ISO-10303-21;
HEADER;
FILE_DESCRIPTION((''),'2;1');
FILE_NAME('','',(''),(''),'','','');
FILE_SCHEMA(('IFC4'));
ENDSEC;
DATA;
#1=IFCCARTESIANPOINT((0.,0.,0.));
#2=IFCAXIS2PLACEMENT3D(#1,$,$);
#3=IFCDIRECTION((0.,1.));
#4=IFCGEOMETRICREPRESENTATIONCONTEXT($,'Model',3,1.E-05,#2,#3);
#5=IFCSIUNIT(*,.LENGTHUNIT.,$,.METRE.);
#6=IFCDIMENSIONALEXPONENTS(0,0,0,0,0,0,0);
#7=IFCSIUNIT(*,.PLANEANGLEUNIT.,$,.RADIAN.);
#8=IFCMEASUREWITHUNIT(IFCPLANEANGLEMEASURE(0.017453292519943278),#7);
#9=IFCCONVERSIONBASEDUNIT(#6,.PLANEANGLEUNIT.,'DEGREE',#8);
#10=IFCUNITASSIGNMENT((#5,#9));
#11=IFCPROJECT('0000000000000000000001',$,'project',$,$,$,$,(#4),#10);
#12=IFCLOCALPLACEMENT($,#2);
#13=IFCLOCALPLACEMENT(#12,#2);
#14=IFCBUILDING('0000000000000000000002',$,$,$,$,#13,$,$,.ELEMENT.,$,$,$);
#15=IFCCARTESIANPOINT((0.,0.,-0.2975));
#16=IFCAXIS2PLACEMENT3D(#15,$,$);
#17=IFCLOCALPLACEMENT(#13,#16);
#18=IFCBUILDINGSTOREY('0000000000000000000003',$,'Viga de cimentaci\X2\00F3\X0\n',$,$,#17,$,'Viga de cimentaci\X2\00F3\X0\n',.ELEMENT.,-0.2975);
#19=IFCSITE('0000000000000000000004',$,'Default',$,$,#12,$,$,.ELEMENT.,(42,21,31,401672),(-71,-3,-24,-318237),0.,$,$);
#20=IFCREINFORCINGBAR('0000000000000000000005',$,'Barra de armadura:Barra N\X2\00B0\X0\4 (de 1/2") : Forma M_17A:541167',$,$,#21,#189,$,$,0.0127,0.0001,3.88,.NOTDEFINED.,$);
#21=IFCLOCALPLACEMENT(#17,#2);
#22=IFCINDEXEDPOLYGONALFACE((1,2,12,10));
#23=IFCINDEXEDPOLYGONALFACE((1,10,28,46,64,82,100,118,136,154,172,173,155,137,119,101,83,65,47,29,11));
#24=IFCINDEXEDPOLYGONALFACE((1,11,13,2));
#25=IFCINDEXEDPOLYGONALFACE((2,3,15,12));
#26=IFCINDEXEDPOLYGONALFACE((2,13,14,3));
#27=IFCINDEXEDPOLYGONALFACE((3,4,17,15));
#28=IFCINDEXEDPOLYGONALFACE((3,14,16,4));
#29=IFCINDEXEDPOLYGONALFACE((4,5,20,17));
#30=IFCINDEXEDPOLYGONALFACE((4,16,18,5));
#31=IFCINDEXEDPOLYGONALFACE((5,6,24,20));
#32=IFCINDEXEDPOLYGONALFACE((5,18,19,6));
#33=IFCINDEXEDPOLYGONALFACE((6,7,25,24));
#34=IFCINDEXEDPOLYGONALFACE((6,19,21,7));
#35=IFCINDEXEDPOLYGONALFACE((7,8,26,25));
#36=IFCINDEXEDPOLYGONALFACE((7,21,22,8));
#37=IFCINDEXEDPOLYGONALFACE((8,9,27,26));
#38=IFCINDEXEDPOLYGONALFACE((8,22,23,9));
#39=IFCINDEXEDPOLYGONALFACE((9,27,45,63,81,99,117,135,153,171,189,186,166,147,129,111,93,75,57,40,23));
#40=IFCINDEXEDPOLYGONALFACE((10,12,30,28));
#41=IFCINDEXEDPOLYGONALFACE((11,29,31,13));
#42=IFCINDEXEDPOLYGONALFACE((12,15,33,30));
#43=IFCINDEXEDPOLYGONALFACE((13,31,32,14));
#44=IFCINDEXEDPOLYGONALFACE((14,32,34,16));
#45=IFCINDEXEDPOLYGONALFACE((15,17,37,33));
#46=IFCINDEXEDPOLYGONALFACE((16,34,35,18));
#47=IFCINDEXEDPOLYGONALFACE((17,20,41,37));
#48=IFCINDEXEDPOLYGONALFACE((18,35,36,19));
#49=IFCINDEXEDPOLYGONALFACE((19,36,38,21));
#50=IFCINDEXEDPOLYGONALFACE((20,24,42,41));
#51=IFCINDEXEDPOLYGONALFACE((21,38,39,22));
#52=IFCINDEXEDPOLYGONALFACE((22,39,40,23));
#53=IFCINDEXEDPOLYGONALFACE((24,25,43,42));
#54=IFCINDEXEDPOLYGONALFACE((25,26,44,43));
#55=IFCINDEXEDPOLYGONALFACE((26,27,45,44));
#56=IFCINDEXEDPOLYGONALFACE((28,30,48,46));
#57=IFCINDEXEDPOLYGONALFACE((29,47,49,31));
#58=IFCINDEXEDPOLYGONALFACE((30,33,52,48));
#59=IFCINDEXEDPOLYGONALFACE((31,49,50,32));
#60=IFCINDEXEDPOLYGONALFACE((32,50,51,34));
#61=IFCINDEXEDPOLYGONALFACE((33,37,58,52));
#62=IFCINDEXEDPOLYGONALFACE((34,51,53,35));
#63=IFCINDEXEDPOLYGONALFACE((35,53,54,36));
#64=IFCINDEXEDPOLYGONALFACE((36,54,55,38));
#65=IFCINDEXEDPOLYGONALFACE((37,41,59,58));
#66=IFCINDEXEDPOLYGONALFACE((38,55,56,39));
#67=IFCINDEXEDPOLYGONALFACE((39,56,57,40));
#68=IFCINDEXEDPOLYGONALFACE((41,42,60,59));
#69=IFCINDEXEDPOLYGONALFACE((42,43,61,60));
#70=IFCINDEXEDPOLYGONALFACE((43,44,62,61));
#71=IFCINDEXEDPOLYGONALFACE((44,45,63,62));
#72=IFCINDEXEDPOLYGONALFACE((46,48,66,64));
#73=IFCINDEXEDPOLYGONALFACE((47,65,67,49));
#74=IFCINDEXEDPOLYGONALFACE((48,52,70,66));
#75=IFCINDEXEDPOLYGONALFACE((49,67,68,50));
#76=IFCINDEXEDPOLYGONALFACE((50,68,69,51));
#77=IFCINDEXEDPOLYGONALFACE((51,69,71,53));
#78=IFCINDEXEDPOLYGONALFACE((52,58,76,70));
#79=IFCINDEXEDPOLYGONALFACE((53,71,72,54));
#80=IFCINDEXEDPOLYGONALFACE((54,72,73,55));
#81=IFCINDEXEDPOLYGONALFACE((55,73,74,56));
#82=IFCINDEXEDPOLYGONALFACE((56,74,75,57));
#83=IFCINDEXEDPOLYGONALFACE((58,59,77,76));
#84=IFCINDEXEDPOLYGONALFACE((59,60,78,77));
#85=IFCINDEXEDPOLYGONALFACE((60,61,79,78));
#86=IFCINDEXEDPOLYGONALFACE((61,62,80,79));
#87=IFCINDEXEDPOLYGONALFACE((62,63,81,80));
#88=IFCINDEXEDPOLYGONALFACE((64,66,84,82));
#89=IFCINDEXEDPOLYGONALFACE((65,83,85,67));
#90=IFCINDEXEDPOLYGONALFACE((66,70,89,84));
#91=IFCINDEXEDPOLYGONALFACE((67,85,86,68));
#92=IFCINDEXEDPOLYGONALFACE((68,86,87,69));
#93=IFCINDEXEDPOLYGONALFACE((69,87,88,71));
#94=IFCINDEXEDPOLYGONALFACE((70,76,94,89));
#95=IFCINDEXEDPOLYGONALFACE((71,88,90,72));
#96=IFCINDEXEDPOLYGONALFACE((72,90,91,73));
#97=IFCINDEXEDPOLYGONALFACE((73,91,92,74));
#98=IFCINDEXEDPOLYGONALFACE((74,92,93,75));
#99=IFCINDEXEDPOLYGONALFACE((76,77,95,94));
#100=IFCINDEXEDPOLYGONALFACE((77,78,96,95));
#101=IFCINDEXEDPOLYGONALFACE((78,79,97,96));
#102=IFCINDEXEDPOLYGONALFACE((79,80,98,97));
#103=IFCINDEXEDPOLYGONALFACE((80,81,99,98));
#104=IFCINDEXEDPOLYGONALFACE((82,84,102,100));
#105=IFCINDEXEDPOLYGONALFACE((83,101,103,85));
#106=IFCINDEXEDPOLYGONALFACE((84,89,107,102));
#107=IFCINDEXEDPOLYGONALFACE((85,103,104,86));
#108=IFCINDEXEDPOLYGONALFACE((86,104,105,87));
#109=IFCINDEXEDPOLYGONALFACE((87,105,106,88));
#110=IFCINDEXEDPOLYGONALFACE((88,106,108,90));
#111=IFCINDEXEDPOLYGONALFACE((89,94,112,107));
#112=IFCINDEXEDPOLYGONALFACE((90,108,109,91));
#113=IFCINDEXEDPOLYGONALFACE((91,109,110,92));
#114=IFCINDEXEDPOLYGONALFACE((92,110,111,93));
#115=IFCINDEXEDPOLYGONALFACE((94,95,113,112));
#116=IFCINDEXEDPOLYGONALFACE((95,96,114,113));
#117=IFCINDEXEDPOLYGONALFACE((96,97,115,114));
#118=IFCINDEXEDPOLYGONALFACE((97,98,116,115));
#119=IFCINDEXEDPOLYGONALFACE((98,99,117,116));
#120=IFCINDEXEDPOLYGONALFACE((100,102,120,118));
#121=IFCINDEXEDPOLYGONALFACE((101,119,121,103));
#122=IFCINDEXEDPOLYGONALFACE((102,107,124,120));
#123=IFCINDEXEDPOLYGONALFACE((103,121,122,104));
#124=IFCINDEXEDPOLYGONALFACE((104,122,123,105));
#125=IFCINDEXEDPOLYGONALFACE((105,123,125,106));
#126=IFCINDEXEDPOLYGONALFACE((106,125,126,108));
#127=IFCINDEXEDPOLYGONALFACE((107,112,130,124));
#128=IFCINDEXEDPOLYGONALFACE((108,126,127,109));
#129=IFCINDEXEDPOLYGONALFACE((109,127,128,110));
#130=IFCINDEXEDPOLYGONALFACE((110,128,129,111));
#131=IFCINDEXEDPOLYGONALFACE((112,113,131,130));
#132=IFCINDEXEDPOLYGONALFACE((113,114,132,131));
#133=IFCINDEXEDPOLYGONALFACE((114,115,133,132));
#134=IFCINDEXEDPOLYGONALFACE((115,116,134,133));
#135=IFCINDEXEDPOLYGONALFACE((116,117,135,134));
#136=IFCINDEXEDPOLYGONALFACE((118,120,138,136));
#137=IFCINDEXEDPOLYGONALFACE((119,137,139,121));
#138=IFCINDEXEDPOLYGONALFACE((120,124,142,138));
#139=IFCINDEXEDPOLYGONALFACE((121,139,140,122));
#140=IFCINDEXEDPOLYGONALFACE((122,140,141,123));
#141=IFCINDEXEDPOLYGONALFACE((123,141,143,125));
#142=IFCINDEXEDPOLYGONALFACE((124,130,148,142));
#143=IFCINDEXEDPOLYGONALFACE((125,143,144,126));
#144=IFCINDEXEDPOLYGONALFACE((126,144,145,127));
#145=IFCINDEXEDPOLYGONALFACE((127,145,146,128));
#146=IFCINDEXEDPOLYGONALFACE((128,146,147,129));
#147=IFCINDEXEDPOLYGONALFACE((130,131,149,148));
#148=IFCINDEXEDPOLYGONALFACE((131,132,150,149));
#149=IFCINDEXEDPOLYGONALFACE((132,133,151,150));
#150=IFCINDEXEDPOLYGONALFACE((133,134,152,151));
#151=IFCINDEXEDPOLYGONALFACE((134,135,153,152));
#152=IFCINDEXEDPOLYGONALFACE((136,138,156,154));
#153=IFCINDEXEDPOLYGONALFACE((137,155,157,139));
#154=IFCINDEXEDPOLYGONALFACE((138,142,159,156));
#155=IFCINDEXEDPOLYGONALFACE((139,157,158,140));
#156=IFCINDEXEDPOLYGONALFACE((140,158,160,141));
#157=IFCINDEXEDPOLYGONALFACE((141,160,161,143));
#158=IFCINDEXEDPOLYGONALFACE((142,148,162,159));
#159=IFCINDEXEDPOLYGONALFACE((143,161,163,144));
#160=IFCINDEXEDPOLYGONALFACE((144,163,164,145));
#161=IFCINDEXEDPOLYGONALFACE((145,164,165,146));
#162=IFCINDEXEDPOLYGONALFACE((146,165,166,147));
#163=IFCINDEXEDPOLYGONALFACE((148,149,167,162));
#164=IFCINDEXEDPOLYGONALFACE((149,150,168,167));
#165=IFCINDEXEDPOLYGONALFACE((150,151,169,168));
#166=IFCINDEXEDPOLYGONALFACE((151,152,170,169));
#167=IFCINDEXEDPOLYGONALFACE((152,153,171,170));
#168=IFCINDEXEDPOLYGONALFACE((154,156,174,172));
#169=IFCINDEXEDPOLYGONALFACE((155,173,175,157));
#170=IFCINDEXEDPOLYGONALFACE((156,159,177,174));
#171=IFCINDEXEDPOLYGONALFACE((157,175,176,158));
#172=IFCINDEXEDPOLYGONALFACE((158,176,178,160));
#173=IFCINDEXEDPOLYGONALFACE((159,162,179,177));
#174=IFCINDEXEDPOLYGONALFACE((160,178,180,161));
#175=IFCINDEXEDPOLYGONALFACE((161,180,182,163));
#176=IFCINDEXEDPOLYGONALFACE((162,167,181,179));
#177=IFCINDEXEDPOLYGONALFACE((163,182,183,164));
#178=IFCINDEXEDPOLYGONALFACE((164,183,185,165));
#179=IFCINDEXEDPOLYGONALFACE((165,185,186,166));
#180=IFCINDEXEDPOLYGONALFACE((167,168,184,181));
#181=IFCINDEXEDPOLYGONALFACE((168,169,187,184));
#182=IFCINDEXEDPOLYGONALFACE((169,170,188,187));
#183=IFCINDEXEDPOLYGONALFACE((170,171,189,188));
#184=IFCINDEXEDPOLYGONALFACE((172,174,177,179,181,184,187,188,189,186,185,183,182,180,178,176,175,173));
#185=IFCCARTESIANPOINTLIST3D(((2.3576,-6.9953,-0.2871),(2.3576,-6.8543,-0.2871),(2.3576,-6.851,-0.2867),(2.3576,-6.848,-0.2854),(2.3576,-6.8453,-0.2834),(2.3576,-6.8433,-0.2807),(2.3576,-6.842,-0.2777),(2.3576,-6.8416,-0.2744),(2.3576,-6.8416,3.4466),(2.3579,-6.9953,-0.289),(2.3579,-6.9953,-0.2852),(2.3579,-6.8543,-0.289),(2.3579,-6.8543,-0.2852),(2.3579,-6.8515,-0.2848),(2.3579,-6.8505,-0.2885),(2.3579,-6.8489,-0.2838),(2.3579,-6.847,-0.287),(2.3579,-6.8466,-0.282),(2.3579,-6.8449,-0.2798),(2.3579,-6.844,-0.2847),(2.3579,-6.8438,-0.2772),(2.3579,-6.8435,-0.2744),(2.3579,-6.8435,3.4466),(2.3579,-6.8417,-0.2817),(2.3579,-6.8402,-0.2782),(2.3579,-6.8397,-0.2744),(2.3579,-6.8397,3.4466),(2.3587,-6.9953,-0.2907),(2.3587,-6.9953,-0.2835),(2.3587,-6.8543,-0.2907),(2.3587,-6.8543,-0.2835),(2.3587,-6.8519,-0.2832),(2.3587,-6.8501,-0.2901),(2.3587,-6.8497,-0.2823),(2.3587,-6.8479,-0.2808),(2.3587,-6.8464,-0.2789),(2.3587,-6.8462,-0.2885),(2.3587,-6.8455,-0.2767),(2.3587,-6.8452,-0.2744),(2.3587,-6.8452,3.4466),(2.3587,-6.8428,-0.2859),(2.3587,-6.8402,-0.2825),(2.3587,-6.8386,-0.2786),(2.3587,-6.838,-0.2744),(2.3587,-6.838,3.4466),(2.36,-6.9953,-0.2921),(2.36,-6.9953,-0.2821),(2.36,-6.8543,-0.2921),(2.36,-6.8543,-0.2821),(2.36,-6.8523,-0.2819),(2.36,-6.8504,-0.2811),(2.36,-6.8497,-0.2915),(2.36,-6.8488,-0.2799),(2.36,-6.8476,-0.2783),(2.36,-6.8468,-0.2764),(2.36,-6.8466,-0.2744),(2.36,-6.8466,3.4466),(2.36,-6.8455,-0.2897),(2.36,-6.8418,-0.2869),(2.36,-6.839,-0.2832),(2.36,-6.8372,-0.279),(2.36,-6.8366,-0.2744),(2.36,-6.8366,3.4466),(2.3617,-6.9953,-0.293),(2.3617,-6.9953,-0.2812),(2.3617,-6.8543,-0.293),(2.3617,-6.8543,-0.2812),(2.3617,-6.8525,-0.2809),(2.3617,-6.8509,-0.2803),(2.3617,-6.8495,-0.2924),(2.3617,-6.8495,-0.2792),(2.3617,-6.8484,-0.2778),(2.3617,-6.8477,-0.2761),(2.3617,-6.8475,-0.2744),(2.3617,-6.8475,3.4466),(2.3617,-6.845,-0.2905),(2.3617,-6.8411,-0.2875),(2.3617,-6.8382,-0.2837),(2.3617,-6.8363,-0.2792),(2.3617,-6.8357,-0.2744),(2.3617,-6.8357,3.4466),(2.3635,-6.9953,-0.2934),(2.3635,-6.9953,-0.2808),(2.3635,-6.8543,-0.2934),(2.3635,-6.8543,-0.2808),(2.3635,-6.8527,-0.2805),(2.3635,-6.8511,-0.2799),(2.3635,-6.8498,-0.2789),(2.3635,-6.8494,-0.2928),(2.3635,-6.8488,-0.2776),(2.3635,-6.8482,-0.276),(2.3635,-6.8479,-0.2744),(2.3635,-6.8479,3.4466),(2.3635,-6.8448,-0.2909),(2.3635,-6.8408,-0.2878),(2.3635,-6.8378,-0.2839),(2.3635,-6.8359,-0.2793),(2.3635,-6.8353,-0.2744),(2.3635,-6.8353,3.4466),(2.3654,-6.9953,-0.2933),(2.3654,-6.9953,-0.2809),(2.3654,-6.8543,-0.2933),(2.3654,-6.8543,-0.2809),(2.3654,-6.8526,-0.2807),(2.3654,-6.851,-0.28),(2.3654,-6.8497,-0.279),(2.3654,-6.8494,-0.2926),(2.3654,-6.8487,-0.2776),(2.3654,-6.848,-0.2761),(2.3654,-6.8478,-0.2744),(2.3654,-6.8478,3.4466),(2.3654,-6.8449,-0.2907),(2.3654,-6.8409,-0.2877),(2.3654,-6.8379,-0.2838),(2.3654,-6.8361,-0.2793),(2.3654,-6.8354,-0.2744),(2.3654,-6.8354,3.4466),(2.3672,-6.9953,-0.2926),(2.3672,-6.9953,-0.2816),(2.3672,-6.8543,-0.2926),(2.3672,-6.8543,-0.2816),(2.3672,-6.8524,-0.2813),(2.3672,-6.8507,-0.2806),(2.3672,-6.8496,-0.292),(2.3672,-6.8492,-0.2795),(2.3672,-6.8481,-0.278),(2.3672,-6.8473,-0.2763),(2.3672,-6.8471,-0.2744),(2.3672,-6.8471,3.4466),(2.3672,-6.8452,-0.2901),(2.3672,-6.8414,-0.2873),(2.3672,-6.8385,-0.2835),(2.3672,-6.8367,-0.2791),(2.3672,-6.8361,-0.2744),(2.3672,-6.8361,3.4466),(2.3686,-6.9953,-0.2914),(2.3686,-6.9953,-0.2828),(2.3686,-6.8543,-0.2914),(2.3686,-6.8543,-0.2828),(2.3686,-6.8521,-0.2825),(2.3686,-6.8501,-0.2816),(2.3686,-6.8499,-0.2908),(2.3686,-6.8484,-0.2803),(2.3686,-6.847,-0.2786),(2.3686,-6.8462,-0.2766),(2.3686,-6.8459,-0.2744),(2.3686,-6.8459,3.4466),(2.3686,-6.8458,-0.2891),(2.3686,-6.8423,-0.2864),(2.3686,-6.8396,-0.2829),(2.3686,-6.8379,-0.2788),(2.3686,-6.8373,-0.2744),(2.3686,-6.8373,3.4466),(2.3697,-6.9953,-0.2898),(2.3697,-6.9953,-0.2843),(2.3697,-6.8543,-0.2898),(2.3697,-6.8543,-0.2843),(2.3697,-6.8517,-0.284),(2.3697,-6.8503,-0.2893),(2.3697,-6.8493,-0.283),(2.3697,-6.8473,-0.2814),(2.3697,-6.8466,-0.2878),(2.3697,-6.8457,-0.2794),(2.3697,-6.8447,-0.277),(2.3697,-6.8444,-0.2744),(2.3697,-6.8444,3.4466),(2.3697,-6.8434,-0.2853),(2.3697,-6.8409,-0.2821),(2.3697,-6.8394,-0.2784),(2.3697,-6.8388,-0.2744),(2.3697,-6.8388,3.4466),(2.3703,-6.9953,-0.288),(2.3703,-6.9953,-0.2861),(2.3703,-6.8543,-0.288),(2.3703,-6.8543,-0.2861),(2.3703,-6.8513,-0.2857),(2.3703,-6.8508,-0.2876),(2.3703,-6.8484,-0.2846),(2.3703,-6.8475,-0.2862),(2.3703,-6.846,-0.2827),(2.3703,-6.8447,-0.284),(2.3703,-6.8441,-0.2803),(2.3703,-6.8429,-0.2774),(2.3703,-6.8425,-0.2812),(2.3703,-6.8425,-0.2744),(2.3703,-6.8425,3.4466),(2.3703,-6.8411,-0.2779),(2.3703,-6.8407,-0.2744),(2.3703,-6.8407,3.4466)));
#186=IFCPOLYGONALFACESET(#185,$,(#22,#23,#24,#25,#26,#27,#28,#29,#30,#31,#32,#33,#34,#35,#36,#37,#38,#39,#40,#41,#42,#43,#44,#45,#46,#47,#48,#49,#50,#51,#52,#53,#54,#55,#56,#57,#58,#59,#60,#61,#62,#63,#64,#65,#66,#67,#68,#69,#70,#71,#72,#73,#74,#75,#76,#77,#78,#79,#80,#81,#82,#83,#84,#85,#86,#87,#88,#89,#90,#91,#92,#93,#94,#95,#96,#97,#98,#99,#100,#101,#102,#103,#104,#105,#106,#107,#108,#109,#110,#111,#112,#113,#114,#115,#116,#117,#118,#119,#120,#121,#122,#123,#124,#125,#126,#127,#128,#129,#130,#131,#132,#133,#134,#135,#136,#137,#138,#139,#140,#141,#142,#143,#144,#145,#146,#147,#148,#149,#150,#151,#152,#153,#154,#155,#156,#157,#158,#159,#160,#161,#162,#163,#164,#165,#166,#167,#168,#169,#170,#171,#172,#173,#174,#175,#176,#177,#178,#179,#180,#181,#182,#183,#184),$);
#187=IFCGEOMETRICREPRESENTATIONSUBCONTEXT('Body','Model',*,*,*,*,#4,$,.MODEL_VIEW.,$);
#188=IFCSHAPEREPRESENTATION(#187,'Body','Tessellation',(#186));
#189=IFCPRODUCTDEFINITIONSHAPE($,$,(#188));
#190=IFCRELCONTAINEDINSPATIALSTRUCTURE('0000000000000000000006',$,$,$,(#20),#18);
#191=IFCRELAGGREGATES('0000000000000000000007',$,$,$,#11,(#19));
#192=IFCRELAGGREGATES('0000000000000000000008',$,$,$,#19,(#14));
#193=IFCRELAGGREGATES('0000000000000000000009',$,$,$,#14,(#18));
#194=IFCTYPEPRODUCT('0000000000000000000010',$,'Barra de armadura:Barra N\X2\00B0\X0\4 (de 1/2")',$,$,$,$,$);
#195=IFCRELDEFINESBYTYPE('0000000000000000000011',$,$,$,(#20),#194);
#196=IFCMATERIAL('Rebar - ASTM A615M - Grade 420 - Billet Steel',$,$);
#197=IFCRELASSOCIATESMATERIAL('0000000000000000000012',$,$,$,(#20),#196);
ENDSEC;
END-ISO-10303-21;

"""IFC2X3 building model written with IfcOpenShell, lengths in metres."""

from ifc_helpers import new_model, entity, si_unit, converted_unit, direction, frame, origin, place, context, subcontext, project, spatial, material, type_object, element, save


model = new_model("IFC2X3")

# Units and contexts
model_context = context("Model", 3, precision=1e-05, world=origin(), true_north=direction((0.0, 1.0)))
body_context = subcontext(model_context, "Body", "Model", "MODEL_VIEW")
ifc_project = project(units=[si_unit("LENGTHUNIT", "METRE"), converted_unit("PLANEANGLEUNIT", "DEGREE", entity("IfcPlaneAngleMeasure", 0.017453292519943278), si_unit("PLANEANGLEUNIT", "RADIAN"), dimensions=[0, 0, 0, 0, 0, 0, 0])], contexts=[model_context])

# Site, building, storey
site_placement = place(None, origin())
site = spatial("IfcSite", under=ifc_project, at=site_placement, Name="Default", CompositionType="ELEMENT", RefLatitude=(42, 21, 31, 401672), RefLongitude=(-71, -3, -24, -318237), RefElevation=0.0)
building_placement = place(site_placement, origin())
building = spatial("IfcBuilding", under=site, at=building_placement, CompositionType="ELEMENT")
storey_placement = place(building_placement, frame((0.0, 0.0, -0.2975)))
storey = spatial("IfcBuildingStorey", under=building, at=storey_placement, Name="Viga de cimentación", LongName="Viga de cimentación", CompositionType="ELEMENT", Elevation=-0.2975)

# Reinforcing bar
ifc_material_1 = material(Name="Rebar - ASTM A615M - Grade 420 - Billet Steel")
type_product_1 = type_object("IfcTypeProduct", Name="Barra de armadura:Barra N°4 (de 1/2\")")
reinforcing_bar_1_placement = place(storey_placement, origin())
element("IfcReinforcingBar", 1, at=reinforcing_bar_1_placement, inside=storey, type_object=type_product_1, material=ifc_material_1, Name="Barra de armadura:Barra N°4 (de 1/2\") : Forma M_17A:541167", BarLength=3.88, BarRole="NOTDEFINED", CrossSectionArea=0.0001, NominalDiameter=0.0127, context=body_context, shape_type="AdvancedSweptSolid", body=[
    entity("IfcSweptDiskSolid", entity("IfcCompositeCurve", [entity("IfcCompositeCurveSegment", "CONTINUOUS", True, entity("IfcPolyline", [entity("IfcCartesianPoint", [2.364, -6.8416, 3.4466]), entity("IfcCartesianPoint", [2.364, -6.8416, -0.2744])])), entity("IfcCompositeCurveSegment", "CONTINUOUS", True, entity("IfcTrimmedCurve", entity("IfcCircle", entity("IfcAxis2Placement3D", entity("IfcCartesianPoint", [2.364, -6.8543, -0.2744]), entity("IfcDirection", [-1.0, 0.0, 0.0]), entity("IfcDirection", [0.0, 0.0, -1.0])), 0.0127), [entity("IfcParameterValue", 270.0)], [entity("IfcParameterValue", 360.0)], True, "PARAMETER")), entity("IfcCompositeCurveSegment", "CONTINUOUS", True, entity("IfcPolyline", [entity("IfcCartesianPoint", [2.364, -6.8543, -0.2871]), entity("IfcCartesianPoint", [2.364, -6.9953, -0.2871])]))], False), 0.0063, None, 0.0, 92.0),
])

save(model, "model.ifc")
